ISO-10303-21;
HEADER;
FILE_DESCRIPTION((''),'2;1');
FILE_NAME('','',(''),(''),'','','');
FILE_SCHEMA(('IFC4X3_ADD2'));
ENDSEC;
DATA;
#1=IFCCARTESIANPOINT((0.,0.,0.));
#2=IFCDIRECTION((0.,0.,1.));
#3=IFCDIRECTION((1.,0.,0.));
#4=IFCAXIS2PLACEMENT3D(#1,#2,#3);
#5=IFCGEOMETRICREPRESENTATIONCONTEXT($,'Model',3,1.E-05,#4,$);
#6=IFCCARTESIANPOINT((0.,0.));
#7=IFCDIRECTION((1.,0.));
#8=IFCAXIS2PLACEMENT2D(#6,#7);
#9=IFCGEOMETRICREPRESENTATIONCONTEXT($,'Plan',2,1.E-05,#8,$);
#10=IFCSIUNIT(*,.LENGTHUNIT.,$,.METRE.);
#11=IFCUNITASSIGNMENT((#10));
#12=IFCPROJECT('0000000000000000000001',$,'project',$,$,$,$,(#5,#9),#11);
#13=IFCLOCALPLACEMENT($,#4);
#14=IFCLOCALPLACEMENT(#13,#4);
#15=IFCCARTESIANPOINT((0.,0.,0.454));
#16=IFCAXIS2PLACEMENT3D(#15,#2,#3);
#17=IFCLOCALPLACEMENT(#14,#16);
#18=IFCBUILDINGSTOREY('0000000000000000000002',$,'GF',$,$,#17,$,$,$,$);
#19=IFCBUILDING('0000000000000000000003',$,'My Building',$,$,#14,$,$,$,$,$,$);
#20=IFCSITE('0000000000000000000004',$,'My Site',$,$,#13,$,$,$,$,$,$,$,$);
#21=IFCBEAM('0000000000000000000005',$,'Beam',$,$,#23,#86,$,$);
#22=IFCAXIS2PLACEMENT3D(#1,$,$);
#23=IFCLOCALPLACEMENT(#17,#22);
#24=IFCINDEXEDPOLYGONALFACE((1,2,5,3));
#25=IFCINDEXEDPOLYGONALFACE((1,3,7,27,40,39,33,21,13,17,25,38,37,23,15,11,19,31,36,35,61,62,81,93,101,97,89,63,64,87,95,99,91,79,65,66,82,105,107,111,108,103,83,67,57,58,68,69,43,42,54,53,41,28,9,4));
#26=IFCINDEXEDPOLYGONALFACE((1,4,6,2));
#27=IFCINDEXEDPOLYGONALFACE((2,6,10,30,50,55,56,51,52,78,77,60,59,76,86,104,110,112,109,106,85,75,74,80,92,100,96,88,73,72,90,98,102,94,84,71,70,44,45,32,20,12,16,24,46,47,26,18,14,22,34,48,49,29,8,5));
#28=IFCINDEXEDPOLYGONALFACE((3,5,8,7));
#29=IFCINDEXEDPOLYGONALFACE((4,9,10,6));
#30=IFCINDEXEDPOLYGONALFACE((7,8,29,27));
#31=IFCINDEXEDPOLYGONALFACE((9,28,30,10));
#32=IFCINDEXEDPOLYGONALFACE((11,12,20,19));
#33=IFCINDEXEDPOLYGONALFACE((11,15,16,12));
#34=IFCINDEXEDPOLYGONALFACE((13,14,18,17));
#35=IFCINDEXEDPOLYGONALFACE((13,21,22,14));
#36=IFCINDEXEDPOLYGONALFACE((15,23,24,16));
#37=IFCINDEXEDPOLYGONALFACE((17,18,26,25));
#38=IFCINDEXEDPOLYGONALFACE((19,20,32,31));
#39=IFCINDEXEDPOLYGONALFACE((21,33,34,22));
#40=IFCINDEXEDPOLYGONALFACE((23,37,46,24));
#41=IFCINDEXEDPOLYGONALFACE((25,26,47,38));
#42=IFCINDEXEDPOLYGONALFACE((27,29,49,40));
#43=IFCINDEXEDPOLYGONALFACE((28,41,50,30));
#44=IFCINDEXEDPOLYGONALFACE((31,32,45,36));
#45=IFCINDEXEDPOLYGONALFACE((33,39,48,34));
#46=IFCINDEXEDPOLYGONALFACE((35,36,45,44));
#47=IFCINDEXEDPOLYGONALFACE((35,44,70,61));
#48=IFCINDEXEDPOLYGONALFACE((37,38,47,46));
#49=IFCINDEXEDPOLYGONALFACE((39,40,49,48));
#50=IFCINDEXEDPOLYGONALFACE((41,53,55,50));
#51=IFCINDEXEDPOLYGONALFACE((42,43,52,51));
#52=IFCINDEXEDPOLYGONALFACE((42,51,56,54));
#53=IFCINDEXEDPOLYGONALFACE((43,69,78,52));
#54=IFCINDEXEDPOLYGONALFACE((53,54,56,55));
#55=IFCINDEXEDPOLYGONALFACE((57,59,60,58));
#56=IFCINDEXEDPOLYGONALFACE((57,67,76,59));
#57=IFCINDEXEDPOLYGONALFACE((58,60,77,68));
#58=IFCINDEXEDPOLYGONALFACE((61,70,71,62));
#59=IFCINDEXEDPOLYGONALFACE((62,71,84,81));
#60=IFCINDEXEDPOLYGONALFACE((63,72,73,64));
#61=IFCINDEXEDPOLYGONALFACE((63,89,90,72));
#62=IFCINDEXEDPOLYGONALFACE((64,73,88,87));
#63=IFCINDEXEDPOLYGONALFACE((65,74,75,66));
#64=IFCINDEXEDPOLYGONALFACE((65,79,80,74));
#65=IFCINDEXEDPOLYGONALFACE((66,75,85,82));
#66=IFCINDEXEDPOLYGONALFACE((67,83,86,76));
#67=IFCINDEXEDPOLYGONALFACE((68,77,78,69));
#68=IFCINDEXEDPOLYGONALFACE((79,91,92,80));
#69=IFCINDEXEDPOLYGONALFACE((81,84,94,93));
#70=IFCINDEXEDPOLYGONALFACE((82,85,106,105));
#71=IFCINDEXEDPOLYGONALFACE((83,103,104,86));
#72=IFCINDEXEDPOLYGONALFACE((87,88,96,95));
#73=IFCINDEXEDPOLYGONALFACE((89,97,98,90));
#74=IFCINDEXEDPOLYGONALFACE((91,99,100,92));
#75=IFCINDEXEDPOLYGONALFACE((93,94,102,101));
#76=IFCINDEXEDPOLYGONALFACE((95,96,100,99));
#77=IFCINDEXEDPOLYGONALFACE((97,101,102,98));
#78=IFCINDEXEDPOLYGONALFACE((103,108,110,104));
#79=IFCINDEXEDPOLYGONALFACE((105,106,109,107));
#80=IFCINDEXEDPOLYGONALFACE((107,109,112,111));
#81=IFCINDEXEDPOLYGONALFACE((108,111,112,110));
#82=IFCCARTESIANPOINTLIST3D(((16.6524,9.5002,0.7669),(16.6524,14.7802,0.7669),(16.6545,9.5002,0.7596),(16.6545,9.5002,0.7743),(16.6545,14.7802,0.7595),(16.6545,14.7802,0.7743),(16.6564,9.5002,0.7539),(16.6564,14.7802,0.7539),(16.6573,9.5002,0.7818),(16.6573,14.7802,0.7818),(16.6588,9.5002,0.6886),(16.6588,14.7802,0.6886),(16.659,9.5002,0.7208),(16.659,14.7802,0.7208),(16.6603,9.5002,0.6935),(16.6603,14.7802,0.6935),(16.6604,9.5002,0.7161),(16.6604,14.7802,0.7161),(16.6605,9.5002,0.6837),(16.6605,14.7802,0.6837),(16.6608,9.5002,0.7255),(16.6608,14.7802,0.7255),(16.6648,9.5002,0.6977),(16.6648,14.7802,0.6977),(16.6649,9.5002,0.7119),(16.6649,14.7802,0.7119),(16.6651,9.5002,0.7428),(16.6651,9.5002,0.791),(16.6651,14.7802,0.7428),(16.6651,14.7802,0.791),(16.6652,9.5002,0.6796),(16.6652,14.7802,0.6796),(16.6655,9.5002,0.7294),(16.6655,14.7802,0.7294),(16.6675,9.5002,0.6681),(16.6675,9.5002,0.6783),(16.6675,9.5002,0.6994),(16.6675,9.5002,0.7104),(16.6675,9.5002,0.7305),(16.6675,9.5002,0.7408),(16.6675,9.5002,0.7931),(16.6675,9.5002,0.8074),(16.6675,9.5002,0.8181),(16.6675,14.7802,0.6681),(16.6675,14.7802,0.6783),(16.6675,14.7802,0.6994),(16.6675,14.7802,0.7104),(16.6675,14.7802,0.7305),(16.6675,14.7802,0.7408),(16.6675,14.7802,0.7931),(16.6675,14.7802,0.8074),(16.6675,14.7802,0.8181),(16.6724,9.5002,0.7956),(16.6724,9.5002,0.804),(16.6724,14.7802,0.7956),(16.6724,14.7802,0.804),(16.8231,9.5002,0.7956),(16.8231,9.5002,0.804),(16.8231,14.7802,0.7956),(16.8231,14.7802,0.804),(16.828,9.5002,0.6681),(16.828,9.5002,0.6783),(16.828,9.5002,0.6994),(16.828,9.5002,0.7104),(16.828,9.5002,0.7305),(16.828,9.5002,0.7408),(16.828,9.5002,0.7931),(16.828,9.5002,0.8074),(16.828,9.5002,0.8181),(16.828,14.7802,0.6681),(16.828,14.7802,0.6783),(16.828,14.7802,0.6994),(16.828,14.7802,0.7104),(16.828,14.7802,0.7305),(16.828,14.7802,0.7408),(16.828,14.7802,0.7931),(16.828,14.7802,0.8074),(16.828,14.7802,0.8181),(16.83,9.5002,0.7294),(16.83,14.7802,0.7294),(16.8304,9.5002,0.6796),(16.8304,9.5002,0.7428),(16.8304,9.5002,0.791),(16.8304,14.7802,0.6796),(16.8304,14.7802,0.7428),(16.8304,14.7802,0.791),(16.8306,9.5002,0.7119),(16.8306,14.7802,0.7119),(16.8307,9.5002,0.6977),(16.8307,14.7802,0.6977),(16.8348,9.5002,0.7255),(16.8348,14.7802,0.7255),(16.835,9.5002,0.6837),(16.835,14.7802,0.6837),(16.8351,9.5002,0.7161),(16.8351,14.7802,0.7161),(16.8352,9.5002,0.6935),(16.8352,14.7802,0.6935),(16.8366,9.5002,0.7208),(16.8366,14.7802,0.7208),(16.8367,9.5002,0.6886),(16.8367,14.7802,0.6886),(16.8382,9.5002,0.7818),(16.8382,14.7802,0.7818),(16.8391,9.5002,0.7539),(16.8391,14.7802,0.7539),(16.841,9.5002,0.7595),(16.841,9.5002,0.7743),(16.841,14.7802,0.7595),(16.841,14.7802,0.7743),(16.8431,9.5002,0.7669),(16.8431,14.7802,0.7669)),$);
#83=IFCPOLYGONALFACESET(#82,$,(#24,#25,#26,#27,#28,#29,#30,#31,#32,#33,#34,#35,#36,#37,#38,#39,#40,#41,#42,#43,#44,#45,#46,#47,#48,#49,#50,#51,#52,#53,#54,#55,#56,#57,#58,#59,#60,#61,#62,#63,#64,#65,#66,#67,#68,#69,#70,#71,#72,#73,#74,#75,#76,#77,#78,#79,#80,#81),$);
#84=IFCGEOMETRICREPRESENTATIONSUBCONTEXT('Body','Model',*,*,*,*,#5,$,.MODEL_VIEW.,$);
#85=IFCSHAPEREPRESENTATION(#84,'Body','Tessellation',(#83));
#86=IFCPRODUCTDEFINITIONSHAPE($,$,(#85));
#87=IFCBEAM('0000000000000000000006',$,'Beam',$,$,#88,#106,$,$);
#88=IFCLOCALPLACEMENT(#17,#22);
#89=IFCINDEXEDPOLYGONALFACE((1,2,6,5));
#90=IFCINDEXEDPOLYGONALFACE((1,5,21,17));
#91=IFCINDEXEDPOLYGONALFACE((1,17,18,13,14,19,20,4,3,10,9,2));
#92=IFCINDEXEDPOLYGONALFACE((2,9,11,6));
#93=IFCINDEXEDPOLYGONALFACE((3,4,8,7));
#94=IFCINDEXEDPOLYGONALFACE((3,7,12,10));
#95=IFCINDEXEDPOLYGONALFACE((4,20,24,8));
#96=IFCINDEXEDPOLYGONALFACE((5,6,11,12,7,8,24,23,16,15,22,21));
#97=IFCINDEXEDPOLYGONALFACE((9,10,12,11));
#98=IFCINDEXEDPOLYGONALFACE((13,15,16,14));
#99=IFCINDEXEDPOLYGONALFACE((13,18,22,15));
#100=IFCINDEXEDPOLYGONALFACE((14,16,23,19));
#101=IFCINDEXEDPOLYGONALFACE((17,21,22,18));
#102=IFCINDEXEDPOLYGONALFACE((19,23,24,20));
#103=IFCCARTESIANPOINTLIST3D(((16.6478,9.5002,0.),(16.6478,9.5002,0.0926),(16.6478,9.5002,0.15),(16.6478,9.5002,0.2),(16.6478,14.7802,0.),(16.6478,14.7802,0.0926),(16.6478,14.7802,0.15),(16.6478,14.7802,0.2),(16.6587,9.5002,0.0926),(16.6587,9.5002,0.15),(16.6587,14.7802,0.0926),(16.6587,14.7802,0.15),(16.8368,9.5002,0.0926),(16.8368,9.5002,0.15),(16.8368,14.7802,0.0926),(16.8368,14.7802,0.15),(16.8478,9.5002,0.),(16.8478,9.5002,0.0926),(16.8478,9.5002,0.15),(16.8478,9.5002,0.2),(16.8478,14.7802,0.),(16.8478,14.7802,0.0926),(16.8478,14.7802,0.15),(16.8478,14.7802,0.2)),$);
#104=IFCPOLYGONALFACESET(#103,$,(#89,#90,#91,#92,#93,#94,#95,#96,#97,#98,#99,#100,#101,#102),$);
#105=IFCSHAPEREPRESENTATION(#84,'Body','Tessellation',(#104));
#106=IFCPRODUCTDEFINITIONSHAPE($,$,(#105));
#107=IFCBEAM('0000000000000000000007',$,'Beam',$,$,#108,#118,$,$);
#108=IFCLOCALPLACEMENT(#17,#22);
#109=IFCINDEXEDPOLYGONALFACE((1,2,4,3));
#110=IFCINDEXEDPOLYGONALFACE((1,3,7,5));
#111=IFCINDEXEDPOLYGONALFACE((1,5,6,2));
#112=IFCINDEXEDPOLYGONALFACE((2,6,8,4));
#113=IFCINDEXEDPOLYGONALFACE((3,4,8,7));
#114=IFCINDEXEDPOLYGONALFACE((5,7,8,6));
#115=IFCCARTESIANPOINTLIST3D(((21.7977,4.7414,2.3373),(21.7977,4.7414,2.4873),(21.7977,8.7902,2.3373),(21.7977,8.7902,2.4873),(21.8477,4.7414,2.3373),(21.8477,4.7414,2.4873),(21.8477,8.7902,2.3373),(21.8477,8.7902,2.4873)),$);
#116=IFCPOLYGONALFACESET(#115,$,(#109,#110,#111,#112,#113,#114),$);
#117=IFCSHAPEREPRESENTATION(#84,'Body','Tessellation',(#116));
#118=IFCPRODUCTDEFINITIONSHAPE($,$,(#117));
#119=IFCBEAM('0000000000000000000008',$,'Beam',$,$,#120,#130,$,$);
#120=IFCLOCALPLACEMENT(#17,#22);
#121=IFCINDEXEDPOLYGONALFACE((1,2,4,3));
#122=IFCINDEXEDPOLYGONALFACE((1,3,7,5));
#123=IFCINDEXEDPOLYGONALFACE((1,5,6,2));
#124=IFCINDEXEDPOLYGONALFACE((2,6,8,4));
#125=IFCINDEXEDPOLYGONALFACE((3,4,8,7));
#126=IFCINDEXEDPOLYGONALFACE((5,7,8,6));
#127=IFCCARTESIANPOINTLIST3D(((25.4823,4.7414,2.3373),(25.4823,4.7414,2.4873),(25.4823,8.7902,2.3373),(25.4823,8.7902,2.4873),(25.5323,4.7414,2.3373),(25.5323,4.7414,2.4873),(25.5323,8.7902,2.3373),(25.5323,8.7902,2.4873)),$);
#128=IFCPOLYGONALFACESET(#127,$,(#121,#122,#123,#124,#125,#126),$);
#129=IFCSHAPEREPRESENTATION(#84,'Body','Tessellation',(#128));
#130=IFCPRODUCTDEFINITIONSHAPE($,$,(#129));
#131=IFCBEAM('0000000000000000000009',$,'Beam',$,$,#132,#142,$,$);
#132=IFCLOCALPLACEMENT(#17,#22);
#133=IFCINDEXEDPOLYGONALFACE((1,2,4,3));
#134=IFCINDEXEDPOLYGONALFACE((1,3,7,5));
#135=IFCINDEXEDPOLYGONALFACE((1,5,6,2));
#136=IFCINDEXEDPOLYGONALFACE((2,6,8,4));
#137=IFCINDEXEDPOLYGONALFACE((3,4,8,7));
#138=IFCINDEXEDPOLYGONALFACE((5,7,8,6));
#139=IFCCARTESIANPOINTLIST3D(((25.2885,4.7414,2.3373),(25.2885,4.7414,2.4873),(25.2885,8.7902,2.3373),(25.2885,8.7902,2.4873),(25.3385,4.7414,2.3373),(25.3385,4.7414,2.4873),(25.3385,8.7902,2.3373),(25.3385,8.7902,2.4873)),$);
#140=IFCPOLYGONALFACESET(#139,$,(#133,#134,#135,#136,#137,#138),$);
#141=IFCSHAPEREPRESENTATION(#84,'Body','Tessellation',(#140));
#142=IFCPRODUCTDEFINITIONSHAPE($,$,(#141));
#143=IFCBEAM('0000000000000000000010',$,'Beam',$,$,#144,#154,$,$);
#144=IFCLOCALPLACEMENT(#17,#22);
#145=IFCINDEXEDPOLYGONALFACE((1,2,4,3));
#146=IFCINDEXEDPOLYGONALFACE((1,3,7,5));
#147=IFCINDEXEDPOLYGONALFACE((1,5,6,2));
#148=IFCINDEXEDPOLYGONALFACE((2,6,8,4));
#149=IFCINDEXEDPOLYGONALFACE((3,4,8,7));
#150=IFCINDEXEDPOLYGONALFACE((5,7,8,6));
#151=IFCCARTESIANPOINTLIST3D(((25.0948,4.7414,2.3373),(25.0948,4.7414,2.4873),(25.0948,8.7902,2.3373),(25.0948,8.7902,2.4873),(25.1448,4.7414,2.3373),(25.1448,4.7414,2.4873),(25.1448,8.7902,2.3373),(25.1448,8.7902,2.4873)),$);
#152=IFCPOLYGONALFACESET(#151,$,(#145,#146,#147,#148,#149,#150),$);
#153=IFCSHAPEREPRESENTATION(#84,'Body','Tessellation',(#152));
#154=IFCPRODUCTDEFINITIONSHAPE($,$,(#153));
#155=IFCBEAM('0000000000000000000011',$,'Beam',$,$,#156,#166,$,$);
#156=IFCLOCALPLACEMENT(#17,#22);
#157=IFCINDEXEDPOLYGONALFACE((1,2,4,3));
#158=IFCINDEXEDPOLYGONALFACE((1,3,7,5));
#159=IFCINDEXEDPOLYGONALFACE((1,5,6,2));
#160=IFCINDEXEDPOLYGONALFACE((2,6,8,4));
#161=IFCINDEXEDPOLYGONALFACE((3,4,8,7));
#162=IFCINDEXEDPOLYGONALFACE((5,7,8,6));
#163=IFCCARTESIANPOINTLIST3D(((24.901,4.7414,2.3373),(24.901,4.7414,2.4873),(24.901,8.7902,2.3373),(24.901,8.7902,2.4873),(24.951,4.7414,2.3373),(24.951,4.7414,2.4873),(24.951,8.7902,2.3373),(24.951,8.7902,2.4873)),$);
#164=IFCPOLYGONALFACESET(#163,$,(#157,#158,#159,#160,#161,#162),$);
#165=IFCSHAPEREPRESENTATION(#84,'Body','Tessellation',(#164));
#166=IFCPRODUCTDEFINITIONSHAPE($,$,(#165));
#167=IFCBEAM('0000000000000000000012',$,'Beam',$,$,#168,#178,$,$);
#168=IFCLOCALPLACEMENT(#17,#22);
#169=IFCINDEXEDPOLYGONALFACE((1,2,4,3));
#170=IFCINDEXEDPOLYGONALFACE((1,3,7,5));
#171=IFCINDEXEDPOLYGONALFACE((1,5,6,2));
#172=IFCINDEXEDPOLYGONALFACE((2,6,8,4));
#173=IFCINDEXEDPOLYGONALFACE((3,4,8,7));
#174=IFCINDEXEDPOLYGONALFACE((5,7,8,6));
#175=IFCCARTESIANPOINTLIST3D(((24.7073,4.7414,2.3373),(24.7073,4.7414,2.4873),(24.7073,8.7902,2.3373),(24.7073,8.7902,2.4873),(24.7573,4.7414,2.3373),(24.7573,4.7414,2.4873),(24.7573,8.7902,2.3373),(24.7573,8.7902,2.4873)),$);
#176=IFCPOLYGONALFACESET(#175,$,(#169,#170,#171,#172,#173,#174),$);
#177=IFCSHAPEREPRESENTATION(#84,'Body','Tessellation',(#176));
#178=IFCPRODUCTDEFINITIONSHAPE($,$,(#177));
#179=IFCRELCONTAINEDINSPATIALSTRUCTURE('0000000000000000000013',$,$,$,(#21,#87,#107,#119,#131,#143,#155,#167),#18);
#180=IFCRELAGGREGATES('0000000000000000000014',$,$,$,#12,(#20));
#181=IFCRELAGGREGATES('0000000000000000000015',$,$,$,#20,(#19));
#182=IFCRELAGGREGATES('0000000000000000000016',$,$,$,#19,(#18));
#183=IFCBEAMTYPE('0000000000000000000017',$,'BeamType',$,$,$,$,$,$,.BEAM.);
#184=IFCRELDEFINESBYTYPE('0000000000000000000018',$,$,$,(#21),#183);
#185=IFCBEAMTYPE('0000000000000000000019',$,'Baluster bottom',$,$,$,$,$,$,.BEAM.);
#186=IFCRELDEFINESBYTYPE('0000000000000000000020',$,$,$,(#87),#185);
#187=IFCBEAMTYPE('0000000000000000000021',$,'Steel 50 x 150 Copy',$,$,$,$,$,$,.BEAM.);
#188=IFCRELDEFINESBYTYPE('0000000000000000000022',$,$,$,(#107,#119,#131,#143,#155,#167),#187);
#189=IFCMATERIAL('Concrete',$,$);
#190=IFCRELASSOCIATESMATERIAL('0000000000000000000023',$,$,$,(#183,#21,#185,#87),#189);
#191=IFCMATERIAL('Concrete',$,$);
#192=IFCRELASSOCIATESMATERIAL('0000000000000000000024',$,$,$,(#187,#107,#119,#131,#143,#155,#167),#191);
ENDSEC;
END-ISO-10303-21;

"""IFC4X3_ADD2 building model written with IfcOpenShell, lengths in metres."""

from ifc_helpers import new_model, si_unit, frame, origin_with_axes, origin_2d_with_axis, place, context, subcontext, project, spatial, indexed_curve, rectangle, outline, extrude, material, material_profile, profile_set, profile_usage, type_object, element, save


model = new_model("IFC4X3_ADD2")

# Units and contexts
model_context = context("Model", 3, precision=1e-05, world=origin_with_axes())
plan_context = context("Plan", 2, precision=1e-05, world=origin_2d_with_axis())
body_context_1 = subcontext(model_context, "Body", "Model", "MODEL_VIEW")
ifc_project = project(units=[si_unit("LENGTHUNIT", "METRE")], contexts=[model_context, plan_context])

# Site, building, storey
site_placement = place(None, origin_with_axes())
site = spatial("IfcSite", under=ifc_project, at=site_placement, Name="My Site")
building_placement = place(site_placement, origin_with_axes())
building = spatial("IfcBuilding", under=site, at=building_placement, Name="My Building")
storey_placement = place(building_placement, frame((0.0, 0.0, 0.454), z_axis=(0.0, 0.0, 1.0), x_axis=(1.0, 0.0, 0.0)))
storey = spatial("IfcBuildingStorey", under=building, at=storey_placement, Name="GF")

# Beams
ifc_material_1 = material(Name="Concrete")
ifc_material_profile_1 = material_profile(ifc_material_1, outline(indexed_curve([(0.0803, 0.0102), (0.0826, 0.0116), (0.0872, 0.0156), (0.0889, 0.0205), (0.0874, 0.0254), (0.083, 0.0297), (0.0803, 0.0314), (0.0803, 0.0423), (0.0828, 0.0439), (0.0873, 0.048), (0.0888, 0.0528), (0.087, 0.0574), (0.0822, 0.0613), (0.0803, 0.0624), (0.0803, 0.0727), (0.0827, 0.0747), (0.0914, 0.0858), (0.0933, 0.0915), (0.0953, 0.0989), (0.0933, 0.1062), (0.0904, 0.1137), (0.0827, 0.123), (0.0803, 0.125), (0.0754, 0.1276), (0.0754, 0.1359), (0.0803, 0.1393), (0.0803, 0.15), (-0.0803, 0.15), (-0.0803, 0.1393), (-0.0754, 0.1359), (-0.0754, 0.1276), (-0.0803, 0.125), (-0.0827, 0.123), (-0.0904, 0.1137), (-0.0933, 0.1062), (-0.0953, 0.0989), (-0.0933, 0.0915), (-0.0914, 0.0858), (-0.0827, 0.0747), (-0.0803, 0.0727), (-0.0803, 0.0624), (-0.0822, 0.0613), (-0.087, 0.0574), (-0.0888, 0.0528), (-0.0873, 0.048), (-0.0828, 0.0439), (-0.0803, 0.0423), (-0.0803, 0.0314), (-0.083, 0.0297), (-0.0874, 0.0254), (-0.0889, 0.0205), (-0.0872, 0.0157), (-0.0826, 0.0116), (-0.0803, 0.0102), (-0.0803, 0.0), (0.0803, 0.0), (0.0803, 0.0102)])))
ifc_profile_set_1 = profile_set([ifc_material_profile_1])
ifc_profile_usage_1 = profile_usage(ifc_profile_set_1, cardinal=5)
beam_type_1 = type_object("IfcBeamType", Name="BeamType", PredefinedType="BEAM", material=ifc_profile_set_1)
beam_1_placement = place(storey_placement, frame((16.7478, 14.7802, 0.6681), z_axis=(0.0, -1.0, 0.0), x_axis=(1.0, 0.0, 0.0)))
element("IfcBeam", 1, at=beam_1_placement, inside=storey, type_object=beam_type_1, material=ifc_profile_usage_1, Name="Beam", context=body_context_1, shape_type="SweptSolid", body=[
    extrude(outline(indexed_curve([(0.0803, 0.0102), (0.0826, 0.0116), (0.0872, 0.0156), (0.0889, 0.0205), (0.0874, 0.0254), (0.083, 0.0297), (0.0803, 0.0314), (0.0803, 0.0423), (0.0828, 0.0439), (0.0873, 0.048), (0.0888, 0.0528), (0.087, 0.0574), (0.0822, 0.0613), (0.0803, 0.0624), (0.0803, 0.0727), (0.0827, 0.0747), (0.0914, 0.0858), (0.0933, 0.0915), (0.0953, 0.0989), (0.0933, 0.1062), (0.0904, 0.1137), (0.0827, 0.123), (0.0803, 0.125), (0.0754, 0.1276), (0.0754, 0.1359), (0.0803, 0.1393), (0.0803, 0.15), (-0.0803, 0.15), (-0.0803, 0.1393), (-0.0754, 0.1359), (-0.0754, 0.1276), (-0.0803, 0.125), (-0.0827, 0.123), (-0.0904, 0.1137), (-0.0933, 0.1062), (-0.0953, 0.0989), (-0.0933, 0.0915), (-0.0914, 0.0858), (-0.0827, 0.0747), (-0.0803, 0.0727), (-0.0803, 0.0624), (-0.0822, 0.0613), (-0.087, 0.0574), (-0.0888, 0.0528), (-0.0873, 0.048), (-0.0828, 0.0439), (-0.0803, 0.0423), (-0.0803, 0.0314), (-0.083, 0.0297), (-0.0874, 0.0254), (-0.0889, 0.0205), (-0.0872, 0.0157), (-0.0826, 0.0116), (-0.0803, 0.0102), (-0.0803, 0.0), (0.0803, 0.0), (0.0803, 0.0102)])), origin_with_axes(), (0.0, 0.0, 1.0), 5.28),
])
ifc_material_profile_2 = material_profile(ifc_material_1, outline(indexed_curve([(0.0891, 0.15), (0.1, 0.15), (0.1, 0.2), (-0.1, 0.2), (-0.1, 0.15), (-0.0891, 0.15), (-0.0891, 0.0926), (-0.1, 0.0926), (-0.1, 0.0), (0.1, 0.0), (0.1, 0.0926), (0.0891, 0.0926), (0.0891, 0.15)])))
ifc_profile_set_2 = profile_set([ifc_material_profile_2])
ifc_profile_usage_2 = profile_usage(ifc_profile_set_2, cardinal=5)
beam_type_2 = type_object("IfcBeamType", Name="Baluster bottom", PredefinedType="BEAM", material=ifc_profile_set_2)
beam_2_placement = place(storey_placement, frame((16.7478, 14.7802, 0.0), z_axis=(0.0, -1.0, 0.0), x_axis=(1.0, 0.0, 0.0)))
element("IfcBeam", 2, at=beam_2_placement, inside=storey, type_object=beam_type_2, material=ifc_profile_usage_2, Name="Beam", context=body_context_1, shape_type="SweptSolid", body=[
    extrude(outline(indexed_curve([(0.0891, 0.15), (0.1, 0.15), (0.1, 0.2), (-0.1, 0.2), (-0.1, 0.15), (-0.0891, 0.15), (-0.0891, 0.0926), (-0.1, 0.0926), (-0.1, 0.0), (0.1, 0.0), (0.1, 0.0926), (0.0891, 0.0926), (0.0891, 0.15)])), origin_with_axes(), (0.0, 0.0, 1.0), 5.28),
])
ifc_material_2 = material(Name="Concrete")
ifc_material_profile_3 = material_profile(ifc_material_2, rectangle(XDim=0.05, YDim=0.15))
ifc_profile_set_3 = profile_set([ifc_material_profile_3])
ifc_profile_usage_3 = profile_usage(ifc_profile_set_3)
beam_type_3 = type_object("IfcBeamType", Name="Steel 50 x 150 Copy", PredefinedType="BEAM", material=ifc_profile_set_3)
beam_3_placement = place(storey_placement, frame((21.8227, 8.7902, 2.4123), z_axis=(0.0, -1.0, 0.0), x_axis=(1.0, 0.0, 0.0)))
element("IfcBeam", 3, at=beam_3_placement, inside=storey, type_object=beam_type_3, material=ifc_profile_usage_3, Name="Beam", context=body_context_1, shape_type="SweptSolid", body=[
    extrude(rectangle(XDim=0.05, YDim=0.15), origin_with_axes(), (0.0, 0.0, 1.0), 4.0488),
])
ifc_profile_usage_4 = profile_usage(ifc_profile_set_3)
beam_4_placement = place(storey_placement, frame((25.5073, 8.7902, 2.4123), z_axis=(0.0, -1.0, 0.0), x_axis=(1.0, 0.0, 0.0)))
element("IfcBeam", 4, at=beam_4_placement, inside=storey, type_object=beam_type_3, material=ifc_profile_usage_4, Name="Beam", context=body_context_1, shape_type="SweptSolid", body=[
    extrude(rectangle(XDim=0.05, YDim=0.15), origin_with_axes(), (0.0, 0.0, 1.0), 4.0488),
])
ifc_profile_usage_5 = profile_usage(ifc_profile_set_3)
beam_5_placement = place(storey_placement, frame((25.3135, 8.7902, 2.4123), z_axis=(0.0, -1.0, 0.0), x_axis=(1.0, 0.0, 0.0)))
element("IfcBeam", 5, at=beam_5_placement, inside=storey, type_object=beam_type_3, material=ifc_profile_usage_5, Name="Beam", context=body_context_1, shape_type="SweptSolid", body=[
    extrude(rectangle(XDim=0.05, YDim=0.15), origin_with_axes(), (0.0, 0.0, 1.0), 4.0488),
])
ifc_profile_usage_6 = profile_usage(ifc_profile_set_3)
beam_6_placement = place(storey_placement, frame((25.1198, 8.7902, 2.4123), z_axis=(0.0, -1.0, 0.0), x_axis=(1.0, 0.0, 0.0)))
element("IfcBeam", 6, at=beam_6_placement, inside=storey, type_object=beam_type_3, material=ifc_profile_usage_6, Name="Beam", context=body_context_1, shape_type="SweptSolid", body=[
    extrude(rectangle(XDim=0.05, YDim=0.15), origin_with_axes(), (0.0, 0.0, 1.0), 4.0488),
])
ifc_profile_usage_7 = profile_usage(ifc_profile_set_3)
beam_7_placement = place(storey_placement, frame((24.926, 8.7902, 2.4123), z_axis=(0.0, -1.0, 0.0), x_axis=(1.0, 0.0, 0.0)))
element("IfcBeam", 7, at=beam_7_placement, inside=storey, type_object=beam_type_3, material=ifc_profile_usage_7, Name="Beam", context=body_context_1, shape_type="SweptSolid", body=[
    extrude(rectangle(XDim=0.05, YDim=0.15), origin_with_axes(), (0.0, 0.0, 1.0), 4.0488),
])
ifc_profile_usage_8 = profile_usage(ifc_profile_set_3)
beam_8_placement = place(storey_placement, frame((24.7323, 8.7902, 2.4123), z_axis=(0.0, -1.0, 0.0), x_axis=(1.0, 0.0, 0.0)))
element("IfcBeam", 8, at=beam_8_placement, inside=storey, type_object=beam_type_3, material=ifc_profile_usage_8, Name="Beam", context=body_context_1, shape_type="SweptSolid", body=[
    extrude(rectangle(XDim=0.05, YDim=0.15), origin_with_axes(), (0.0, 0.0, 1.0), 4.0488),
])

save(model, "model.ifc")
